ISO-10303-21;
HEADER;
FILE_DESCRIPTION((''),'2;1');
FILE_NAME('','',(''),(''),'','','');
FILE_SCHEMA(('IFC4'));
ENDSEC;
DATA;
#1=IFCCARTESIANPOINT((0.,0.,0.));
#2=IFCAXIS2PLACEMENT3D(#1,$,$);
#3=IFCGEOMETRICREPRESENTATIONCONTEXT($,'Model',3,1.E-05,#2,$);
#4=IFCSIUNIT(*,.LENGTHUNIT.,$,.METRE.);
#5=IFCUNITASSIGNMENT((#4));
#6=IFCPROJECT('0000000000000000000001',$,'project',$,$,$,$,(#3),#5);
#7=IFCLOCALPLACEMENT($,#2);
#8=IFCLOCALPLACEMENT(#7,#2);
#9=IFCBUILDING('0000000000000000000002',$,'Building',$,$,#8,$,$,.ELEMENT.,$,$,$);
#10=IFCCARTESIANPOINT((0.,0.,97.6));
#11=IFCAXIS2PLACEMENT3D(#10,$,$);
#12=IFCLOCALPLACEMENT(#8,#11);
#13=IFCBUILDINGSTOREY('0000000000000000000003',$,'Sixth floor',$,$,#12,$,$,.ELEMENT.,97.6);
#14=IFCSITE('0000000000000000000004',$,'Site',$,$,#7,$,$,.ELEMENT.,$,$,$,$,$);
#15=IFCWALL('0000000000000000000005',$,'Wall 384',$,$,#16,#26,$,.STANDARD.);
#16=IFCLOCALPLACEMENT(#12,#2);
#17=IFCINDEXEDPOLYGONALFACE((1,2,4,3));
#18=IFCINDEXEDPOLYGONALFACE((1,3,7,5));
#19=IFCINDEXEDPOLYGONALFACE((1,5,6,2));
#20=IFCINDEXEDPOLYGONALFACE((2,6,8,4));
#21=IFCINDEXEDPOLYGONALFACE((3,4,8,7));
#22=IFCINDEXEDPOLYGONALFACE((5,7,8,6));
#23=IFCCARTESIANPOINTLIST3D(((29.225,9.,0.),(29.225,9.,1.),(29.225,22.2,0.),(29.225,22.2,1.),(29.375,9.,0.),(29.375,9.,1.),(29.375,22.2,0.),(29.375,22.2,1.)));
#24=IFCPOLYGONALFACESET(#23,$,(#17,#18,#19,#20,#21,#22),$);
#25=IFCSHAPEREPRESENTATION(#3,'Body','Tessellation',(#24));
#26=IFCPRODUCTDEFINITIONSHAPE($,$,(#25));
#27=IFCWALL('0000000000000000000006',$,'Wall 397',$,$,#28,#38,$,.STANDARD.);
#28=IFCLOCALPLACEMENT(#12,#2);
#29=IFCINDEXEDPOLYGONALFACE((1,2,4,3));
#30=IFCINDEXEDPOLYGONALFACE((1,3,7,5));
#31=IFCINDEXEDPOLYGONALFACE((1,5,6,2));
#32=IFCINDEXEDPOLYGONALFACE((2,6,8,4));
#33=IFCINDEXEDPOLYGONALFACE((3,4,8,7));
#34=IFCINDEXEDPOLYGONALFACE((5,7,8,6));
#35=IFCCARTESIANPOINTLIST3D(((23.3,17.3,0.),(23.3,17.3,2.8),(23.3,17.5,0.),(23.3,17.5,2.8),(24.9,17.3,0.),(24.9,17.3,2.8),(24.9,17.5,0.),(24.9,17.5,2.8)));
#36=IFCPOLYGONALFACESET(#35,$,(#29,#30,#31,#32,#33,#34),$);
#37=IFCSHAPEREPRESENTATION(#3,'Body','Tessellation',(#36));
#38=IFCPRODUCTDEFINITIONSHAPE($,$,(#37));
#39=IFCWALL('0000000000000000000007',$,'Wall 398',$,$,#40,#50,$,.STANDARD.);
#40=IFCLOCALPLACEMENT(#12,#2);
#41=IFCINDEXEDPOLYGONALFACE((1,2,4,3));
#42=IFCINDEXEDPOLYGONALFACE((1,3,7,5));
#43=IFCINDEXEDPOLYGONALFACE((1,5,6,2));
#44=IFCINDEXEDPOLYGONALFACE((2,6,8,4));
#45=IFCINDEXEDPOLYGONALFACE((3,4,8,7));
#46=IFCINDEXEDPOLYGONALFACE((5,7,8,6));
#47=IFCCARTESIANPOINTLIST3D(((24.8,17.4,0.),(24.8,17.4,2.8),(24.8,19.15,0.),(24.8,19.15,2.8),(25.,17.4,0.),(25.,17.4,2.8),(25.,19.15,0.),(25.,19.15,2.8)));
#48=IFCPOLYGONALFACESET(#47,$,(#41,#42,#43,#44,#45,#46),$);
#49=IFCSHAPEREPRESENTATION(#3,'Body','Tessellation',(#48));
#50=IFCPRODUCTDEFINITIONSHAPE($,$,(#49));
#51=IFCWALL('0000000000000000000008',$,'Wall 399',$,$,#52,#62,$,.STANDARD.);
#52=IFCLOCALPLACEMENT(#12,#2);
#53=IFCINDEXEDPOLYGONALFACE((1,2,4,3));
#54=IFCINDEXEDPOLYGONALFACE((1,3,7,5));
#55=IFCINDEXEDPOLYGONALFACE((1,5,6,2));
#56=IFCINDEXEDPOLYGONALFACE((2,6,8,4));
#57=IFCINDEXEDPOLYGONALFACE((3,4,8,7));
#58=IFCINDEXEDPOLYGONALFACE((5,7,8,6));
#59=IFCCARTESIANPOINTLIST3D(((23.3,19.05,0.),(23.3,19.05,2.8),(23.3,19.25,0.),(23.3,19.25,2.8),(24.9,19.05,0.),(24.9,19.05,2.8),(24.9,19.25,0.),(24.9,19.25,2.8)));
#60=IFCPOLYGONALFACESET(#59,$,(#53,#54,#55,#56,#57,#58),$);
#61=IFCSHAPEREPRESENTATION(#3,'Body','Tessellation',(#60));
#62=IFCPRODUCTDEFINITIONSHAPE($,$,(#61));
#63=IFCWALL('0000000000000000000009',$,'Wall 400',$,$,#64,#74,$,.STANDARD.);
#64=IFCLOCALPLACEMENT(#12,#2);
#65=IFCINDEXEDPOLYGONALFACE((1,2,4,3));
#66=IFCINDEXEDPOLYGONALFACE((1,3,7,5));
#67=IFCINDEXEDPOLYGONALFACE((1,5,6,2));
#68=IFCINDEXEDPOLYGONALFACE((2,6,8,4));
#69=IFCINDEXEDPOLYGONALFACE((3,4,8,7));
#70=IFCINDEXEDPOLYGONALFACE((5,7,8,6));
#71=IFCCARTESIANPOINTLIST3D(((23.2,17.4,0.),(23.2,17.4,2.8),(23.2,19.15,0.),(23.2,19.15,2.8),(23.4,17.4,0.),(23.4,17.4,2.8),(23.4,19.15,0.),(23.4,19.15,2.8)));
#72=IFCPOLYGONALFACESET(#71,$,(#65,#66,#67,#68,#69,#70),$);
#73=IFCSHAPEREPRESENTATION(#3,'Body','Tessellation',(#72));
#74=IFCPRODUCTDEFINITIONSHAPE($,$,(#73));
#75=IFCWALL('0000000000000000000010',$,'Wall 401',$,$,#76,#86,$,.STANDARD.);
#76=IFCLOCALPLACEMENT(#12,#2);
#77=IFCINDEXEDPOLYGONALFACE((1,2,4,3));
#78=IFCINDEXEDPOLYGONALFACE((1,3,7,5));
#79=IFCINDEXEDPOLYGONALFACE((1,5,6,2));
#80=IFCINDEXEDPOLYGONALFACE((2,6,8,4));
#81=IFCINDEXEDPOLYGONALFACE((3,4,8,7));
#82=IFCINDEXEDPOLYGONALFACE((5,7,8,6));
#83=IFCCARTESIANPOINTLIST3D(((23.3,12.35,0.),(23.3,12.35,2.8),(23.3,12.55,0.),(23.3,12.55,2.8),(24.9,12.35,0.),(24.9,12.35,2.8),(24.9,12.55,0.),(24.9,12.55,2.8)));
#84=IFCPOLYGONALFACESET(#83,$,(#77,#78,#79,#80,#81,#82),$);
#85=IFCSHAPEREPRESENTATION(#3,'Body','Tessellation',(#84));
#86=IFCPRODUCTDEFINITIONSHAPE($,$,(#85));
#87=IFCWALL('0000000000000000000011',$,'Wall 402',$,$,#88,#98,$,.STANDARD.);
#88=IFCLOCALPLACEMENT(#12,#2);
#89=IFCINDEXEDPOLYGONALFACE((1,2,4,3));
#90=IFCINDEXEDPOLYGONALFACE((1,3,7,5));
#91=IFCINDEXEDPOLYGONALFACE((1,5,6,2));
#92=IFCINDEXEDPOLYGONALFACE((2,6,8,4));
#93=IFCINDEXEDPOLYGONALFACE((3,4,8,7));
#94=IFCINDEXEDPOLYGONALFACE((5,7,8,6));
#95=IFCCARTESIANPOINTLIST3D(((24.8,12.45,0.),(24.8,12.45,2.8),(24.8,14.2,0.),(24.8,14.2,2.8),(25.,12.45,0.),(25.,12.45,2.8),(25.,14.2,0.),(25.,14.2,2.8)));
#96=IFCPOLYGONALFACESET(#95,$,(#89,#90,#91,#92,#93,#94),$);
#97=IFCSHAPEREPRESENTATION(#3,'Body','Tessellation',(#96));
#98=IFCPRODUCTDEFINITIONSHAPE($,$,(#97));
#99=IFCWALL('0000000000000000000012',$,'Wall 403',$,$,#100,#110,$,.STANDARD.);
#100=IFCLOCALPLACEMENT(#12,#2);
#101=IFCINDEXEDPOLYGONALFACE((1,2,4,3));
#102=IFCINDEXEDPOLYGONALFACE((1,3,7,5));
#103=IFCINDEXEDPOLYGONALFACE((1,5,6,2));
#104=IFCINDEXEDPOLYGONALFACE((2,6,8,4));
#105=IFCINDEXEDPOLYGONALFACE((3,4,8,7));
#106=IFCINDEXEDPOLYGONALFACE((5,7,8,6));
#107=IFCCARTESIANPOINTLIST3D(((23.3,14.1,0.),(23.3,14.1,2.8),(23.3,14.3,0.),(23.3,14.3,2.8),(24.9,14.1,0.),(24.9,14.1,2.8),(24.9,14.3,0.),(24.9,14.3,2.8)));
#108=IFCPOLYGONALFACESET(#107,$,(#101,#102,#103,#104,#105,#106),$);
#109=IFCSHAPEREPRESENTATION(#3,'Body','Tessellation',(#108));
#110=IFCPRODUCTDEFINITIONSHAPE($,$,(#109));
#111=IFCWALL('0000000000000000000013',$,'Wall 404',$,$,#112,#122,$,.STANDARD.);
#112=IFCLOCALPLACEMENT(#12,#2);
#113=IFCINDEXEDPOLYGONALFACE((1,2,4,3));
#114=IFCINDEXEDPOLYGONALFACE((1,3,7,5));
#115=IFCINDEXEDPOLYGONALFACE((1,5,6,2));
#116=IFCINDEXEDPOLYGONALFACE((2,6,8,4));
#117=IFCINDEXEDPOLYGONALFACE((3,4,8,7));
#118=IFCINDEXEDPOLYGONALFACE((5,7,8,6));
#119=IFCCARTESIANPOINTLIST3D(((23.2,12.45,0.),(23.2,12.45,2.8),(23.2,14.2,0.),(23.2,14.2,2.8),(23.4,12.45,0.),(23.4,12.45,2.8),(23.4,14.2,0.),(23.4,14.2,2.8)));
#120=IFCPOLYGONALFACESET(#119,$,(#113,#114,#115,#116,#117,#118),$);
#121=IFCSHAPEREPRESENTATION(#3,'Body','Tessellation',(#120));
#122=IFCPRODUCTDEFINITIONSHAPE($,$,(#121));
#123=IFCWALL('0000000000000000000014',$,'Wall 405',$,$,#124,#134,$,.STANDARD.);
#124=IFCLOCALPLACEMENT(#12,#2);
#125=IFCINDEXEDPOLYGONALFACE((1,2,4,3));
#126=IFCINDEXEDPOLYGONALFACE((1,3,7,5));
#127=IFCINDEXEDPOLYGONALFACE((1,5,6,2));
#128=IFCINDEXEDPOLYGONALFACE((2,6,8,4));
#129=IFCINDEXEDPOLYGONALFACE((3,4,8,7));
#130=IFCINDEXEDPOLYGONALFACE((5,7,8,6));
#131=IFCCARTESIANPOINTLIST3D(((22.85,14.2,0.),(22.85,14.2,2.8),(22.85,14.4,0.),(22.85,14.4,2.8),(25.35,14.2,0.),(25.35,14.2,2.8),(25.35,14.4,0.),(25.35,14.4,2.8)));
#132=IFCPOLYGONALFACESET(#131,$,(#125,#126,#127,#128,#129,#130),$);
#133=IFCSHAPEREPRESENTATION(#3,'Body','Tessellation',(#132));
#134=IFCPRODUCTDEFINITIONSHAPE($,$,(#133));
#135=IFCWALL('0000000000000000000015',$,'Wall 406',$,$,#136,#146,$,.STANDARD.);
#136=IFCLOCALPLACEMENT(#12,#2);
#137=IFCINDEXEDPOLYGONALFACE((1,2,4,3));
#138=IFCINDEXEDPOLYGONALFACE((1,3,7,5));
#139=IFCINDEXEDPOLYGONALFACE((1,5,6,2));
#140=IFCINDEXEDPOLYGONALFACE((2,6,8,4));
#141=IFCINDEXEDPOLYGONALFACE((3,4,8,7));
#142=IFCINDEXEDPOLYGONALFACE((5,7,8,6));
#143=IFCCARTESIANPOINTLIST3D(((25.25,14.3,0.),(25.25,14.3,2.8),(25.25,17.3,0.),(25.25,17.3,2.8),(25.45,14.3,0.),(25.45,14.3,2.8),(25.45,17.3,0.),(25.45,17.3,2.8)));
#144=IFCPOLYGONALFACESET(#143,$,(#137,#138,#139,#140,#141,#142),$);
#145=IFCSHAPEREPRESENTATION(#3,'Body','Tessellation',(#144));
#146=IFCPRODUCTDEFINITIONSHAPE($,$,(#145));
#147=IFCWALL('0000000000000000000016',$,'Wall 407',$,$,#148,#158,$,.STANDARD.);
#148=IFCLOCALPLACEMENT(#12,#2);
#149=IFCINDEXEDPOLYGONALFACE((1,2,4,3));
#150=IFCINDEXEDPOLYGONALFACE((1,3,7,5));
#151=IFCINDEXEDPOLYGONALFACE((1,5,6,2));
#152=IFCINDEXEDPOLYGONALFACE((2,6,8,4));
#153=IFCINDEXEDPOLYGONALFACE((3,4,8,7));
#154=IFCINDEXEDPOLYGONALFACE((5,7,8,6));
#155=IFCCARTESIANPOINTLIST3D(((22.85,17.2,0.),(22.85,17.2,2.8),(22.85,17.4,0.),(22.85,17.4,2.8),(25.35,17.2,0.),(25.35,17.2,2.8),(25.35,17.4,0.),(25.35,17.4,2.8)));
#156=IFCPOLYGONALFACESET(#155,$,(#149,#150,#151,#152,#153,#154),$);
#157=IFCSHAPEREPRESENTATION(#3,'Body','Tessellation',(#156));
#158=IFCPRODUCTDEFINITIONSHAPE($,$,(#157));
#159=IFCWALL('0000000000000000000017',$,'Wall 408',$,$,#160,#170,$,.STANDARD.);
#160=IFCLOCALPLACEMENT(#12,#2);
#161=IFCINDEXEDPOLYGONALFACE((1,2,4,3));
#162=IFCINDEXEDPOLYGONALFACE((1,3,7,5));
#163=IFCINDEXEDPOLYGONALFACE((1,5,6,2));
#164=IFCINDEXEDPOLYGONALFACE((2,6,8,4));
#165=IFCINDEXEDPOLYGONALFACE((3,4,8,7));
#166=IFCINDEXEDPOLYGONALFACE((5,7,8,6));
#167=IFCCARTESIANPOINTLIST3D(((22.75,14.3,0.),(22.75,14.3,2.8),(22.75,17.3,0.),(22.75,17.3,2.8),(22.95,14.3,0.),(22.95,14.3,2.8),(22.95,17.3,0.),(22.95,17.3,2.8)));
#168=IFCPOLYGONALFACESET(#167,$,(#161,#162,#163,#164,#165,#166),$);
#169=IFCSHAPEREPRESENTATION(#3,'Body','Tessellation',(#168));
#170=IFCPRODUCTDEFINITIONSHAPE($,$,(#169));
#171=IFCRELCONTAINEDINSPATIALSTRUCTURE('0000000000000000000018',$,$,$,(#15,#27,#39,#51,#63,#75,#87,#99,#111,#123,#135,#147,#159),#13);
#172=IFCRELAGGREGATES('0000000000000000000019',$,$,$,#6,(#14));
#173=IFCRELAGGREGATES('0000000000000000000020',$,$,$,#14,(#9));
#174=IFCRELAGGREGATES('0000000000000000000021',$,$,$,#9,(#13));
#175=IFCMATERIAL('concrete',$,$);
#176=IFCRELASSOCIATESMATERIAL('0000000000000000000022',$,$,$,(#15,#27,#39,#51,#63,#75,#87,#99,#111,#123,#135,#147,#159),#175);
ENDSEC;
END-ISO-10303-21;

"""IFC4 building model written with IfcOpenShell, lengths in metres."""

from ifc_helpers import new_model, si_unit, frame, frame_2d, origin, place, context, project, spatial, rectangle, extrude, material, element, save


model = new_model("IFC4")

# Units and contexts
model_context = context("Model", 3, precision=1e-05, world=origin())
ifc_project = project(units=[si_unit("LENGTHUNIT", "METRE")], contexts=[model_context])

# Site, building, storey
site_placement = place(None, origin())
site = spatial("IfcSite", under=ifc_project, at=site_placement, Name="Site", CompositionType="ELEMENT")
building_placement = place(site_placement, origin())
building = spatial("IfcBuilding", under=site, at=building_placement, Name="Building", CompositionType="ELEMENT")
storey_placement = place(building_placement, frame((0.0, 0.0, 97.6)))
storey = spatial("IfcBuildingStorey", under=building, at=storey_placement, Name="Sixth floor", CompositionType="ELEMENT", Elevation=97.6)

# Shared definitions
ifc_material = material(Name="concrete")

# Walls
wall_1_placement = place(storey_placement, frame((29.3, 22.2, 0.0), z_axis=(0.0, 0.0, 1.0), x_axis=(0.0, -1.0, 0.0)))
element("IfcWall", 1, at=wall_1_placement, inside=storey, material=ifc_material, Name="Wall 384", PredefinedType="STANDARD", context=model_context, shape_type="SweptSolid", body=[
    extrude(rectangle(XDim=13.2, YDim=0.15, at=frame_2d((6.6, 0.0))), origin(), (0.0, 0.0, 1.0), 1.0),
])
wall_2_placement = place(storey_placement, frame((23.3, 17.4, 0.0), z_axis=(0.0, 0.0, 1.0), x_axis=(1.0, 0.0, 0.0)))
element("IfcWall", 2, at=wall_2_placement, inside=storey, material=ifc_material, Name="Wall 397", PredefinedType="STANDARD", context=model_context, shape_type="SweptSolid", body=[
    extrude(rectangle(XDim=1.6, YDim=0.2, at=frame_2d((0.8, 0.0))), origin(), (0.0, 0.0, 1.0), 2.8),
])
wall_3_placement = place(storey_placement, frame((24.9, 17.4, 0.0), z_axis=(0.0, 0.0, 1.0), x_axis=(0.0, 1.0, 0.0)))
element("IfcWall", 3, at=wall_3_placement, inside=storey, material=ifc_material, Name="Wall 398", PredefinedType="STANDARD", context=model_context, shape_type="SweptSolid", body=[
    extrude(rectangle(XDim=1.75, YDim=0.2, at=frame_2d((0.875, 0.0))), origin(), (0.0, 0.0, 1.0), 2.8),
])
wall_4_placement = place(storey_placement, frame((24.9, 19.15, 0.0), z_axis=(0.0, 0.0, 1.0), x_axis=(-1.0, 0.0, 0.0)))
element("IfcWall", 4, at=wall_4_placement, inside=storey, material=ifc_material, Name="Wall 399", PredefinedType="STANDARD", context=model_context, shape_type="SweptSolid", body=[
    extrude(rectangle(XDim=1.6, YDim=0.2, at=frame_2d((0.8, 0.0))), origin(), (0.0, 0.0, 1.0), 2.8),
])
wall_5_placement = place(storey_placement, frame((23.3, 19.15, 0.0), z_axis=(0.0, 0.0, 1.0), x_axis=(0.0, -1.0, 0.0)))
element("IfcWall", 5, at=wall_5_placement, inside=storey, material=ifc_material, Name="Wall 400", PredefinedType="STANDARD", context=model_context, shape_type="SweptSolid", body=[
    extrude(rectangle(XDim=1.75, YDim=0.2, at=frame_2d((0.875, 0.0))), origin(), (0.0, 0.0, 1.0), 2.8),
])
wall_6_placement = place(storey_placement, frame((23.3, 12.45, 0.0), z_axis=(0.0, 0.0, 1.0), x_axis=(1.0, 0.0, 0.0)))
element("IfcWall", 6, at=wall_6_placement, inside=storey, material=ifc_material, Name="Wall 401", PredefinedType="STANDARD", context=model_context, shape_type="SweptSolid", body=[
    extrude(rectangle(XDim=1.6, YDim=0.2, at=frame_2d((0.8, 0.0))), origin(), (0.0, 0.0, 1.0), 2.8),
])
wall_7_placement = place(storey_placement, frame((24.9, 12.45, 0.0), z_axis=(0.0, 0.0, 1.0), x_axis=(0.0, 1.0, 0.0)))
element("IfcWall", 7, at=wall_7_placement, inside=storey, material=ifc_material, Name="Wall 402", PredefinedType="STANDARD", context=model_context, shape_type="SweptSolid", body=[
    extrude(rectangle(XDim=1.75, YDim=0.2, at=frame_2d((0.875, 0.0))), origin(), (0.0, 0.0, 1.0), 2.8),
])
wall_8_placement = place(storey_placement, frame((24.9, 14.2, 0.0), z_axis=(0.0, 0.0, 1.0), x_axis=(-1.0, 0.0, 0.0)))
element("IfcWall", 8, at=wall_8_placement, inside=storey, material=ifc_material, Name="Wall 403", PredefinedType="STANDARD", context=model_context, shape_type="SweptSolid", body=[
    extrude(rectangle(XDim=1.6, YDim=0.2, at=frame_2d((0.8, 0.0))), origin(), (0.0, 0.0, 1.0), 2.8),
])
wall_9_placement = place(storey_placement, frame((23.3, 14.2, 0.0), z_axis=(0.0, 0.0, 1.0), x_axis=(0.0, -1.0, 0.0)))
element("IfcWall", 9, at=wall_9_placement, inside=storey, material=ifc_material, Name="Wall 404", PredefinedType="STANDARD", context=model_context, shape_type="SweptSolid", body=[
    extrude(rectangle(XDim=1.75, YDim=0.2, at=frame_2d((0.875, 0.0))), origin(), (0.0, 0.0, 1.0), 2.8),
])
wall_10_placement = place(storey_placement, frame((22.85, 14.3, 0.0), z_axis=(0.0, 0.0, 1.0), x_axis=(1.0, 0.0, 0.0)))
element("IfcWall", 10, at=wall_10_placement, inside=storey, material=ifc_material, Name="Wall 405", PredefinedType="STANDARD", context=model_context, shape_type="SweptSolid", body=[
    extrude(rectangle(XDim=2.5, YDim=0.2, at=frame_2d((1.25, 0.0))), origin(), (0.0, 0.0, 1.0), 2.8),
])
wall_11_placement = place(storey_placement, frame((25.35, 14.3, 0.0), z_axis=(0.0, 0.0, 1.0), x_axis=(0.0, 1.0, 0.0)))
element("IfcWall", 11, at=wall_11_placement, inside=storey, material=ifc_material, Name="Wall 406", PredefinedType="STANDARD", context=model_context, shape_type="SweptSolid", body=[
    extrude(rectangle(XDim=3.0, YDim=0.2, at=frame_2d((1.5, 0.0))), origin(), (0.0, 0.0, 1.0), 2.8),
])
wall_12_placement = place(storey_placement, frame((25.35, 17.3, 0.0), z_axis=(0.0, 0.0, 1.0), x_axis=(-1.0, 0.0, 0.0)))
element("IfcWall", 12, at=wall_12_placement, inside=storey, material=ifc_material, Name="Wall 407", PredefinedType="STANDARD", context=model_context, shape_type="SweptSolid", body=[
    extrude(rectangle(XDim=2.5, YDim=0.2, at=frame_2d((1.25, 0.0))), origin(), (0.0, 0.0, 1.0), 2.8),
])
wall_13_placement = place(storey_placement, frame((22.85, 17.3, 0.0), z_axis=(0.0, 0.0, 1.0), x_axis=(0.0, -1.0, 0.0)))
element("IfcWall", 13, at=wall_13_placement, inside=storey, material=ifc_material, Name="Wall 408", PredefinedType="STANDARD", context=model_context, shape_type="SweptSolid", body=[
    extrude(rectangle(XDim=3.0, YDim=0.2, at=frame_2d((1.5, 0.0))), origin(), (0.0, 0.0, 1.0), 2.8),
])

save(model, "model.ifc")
